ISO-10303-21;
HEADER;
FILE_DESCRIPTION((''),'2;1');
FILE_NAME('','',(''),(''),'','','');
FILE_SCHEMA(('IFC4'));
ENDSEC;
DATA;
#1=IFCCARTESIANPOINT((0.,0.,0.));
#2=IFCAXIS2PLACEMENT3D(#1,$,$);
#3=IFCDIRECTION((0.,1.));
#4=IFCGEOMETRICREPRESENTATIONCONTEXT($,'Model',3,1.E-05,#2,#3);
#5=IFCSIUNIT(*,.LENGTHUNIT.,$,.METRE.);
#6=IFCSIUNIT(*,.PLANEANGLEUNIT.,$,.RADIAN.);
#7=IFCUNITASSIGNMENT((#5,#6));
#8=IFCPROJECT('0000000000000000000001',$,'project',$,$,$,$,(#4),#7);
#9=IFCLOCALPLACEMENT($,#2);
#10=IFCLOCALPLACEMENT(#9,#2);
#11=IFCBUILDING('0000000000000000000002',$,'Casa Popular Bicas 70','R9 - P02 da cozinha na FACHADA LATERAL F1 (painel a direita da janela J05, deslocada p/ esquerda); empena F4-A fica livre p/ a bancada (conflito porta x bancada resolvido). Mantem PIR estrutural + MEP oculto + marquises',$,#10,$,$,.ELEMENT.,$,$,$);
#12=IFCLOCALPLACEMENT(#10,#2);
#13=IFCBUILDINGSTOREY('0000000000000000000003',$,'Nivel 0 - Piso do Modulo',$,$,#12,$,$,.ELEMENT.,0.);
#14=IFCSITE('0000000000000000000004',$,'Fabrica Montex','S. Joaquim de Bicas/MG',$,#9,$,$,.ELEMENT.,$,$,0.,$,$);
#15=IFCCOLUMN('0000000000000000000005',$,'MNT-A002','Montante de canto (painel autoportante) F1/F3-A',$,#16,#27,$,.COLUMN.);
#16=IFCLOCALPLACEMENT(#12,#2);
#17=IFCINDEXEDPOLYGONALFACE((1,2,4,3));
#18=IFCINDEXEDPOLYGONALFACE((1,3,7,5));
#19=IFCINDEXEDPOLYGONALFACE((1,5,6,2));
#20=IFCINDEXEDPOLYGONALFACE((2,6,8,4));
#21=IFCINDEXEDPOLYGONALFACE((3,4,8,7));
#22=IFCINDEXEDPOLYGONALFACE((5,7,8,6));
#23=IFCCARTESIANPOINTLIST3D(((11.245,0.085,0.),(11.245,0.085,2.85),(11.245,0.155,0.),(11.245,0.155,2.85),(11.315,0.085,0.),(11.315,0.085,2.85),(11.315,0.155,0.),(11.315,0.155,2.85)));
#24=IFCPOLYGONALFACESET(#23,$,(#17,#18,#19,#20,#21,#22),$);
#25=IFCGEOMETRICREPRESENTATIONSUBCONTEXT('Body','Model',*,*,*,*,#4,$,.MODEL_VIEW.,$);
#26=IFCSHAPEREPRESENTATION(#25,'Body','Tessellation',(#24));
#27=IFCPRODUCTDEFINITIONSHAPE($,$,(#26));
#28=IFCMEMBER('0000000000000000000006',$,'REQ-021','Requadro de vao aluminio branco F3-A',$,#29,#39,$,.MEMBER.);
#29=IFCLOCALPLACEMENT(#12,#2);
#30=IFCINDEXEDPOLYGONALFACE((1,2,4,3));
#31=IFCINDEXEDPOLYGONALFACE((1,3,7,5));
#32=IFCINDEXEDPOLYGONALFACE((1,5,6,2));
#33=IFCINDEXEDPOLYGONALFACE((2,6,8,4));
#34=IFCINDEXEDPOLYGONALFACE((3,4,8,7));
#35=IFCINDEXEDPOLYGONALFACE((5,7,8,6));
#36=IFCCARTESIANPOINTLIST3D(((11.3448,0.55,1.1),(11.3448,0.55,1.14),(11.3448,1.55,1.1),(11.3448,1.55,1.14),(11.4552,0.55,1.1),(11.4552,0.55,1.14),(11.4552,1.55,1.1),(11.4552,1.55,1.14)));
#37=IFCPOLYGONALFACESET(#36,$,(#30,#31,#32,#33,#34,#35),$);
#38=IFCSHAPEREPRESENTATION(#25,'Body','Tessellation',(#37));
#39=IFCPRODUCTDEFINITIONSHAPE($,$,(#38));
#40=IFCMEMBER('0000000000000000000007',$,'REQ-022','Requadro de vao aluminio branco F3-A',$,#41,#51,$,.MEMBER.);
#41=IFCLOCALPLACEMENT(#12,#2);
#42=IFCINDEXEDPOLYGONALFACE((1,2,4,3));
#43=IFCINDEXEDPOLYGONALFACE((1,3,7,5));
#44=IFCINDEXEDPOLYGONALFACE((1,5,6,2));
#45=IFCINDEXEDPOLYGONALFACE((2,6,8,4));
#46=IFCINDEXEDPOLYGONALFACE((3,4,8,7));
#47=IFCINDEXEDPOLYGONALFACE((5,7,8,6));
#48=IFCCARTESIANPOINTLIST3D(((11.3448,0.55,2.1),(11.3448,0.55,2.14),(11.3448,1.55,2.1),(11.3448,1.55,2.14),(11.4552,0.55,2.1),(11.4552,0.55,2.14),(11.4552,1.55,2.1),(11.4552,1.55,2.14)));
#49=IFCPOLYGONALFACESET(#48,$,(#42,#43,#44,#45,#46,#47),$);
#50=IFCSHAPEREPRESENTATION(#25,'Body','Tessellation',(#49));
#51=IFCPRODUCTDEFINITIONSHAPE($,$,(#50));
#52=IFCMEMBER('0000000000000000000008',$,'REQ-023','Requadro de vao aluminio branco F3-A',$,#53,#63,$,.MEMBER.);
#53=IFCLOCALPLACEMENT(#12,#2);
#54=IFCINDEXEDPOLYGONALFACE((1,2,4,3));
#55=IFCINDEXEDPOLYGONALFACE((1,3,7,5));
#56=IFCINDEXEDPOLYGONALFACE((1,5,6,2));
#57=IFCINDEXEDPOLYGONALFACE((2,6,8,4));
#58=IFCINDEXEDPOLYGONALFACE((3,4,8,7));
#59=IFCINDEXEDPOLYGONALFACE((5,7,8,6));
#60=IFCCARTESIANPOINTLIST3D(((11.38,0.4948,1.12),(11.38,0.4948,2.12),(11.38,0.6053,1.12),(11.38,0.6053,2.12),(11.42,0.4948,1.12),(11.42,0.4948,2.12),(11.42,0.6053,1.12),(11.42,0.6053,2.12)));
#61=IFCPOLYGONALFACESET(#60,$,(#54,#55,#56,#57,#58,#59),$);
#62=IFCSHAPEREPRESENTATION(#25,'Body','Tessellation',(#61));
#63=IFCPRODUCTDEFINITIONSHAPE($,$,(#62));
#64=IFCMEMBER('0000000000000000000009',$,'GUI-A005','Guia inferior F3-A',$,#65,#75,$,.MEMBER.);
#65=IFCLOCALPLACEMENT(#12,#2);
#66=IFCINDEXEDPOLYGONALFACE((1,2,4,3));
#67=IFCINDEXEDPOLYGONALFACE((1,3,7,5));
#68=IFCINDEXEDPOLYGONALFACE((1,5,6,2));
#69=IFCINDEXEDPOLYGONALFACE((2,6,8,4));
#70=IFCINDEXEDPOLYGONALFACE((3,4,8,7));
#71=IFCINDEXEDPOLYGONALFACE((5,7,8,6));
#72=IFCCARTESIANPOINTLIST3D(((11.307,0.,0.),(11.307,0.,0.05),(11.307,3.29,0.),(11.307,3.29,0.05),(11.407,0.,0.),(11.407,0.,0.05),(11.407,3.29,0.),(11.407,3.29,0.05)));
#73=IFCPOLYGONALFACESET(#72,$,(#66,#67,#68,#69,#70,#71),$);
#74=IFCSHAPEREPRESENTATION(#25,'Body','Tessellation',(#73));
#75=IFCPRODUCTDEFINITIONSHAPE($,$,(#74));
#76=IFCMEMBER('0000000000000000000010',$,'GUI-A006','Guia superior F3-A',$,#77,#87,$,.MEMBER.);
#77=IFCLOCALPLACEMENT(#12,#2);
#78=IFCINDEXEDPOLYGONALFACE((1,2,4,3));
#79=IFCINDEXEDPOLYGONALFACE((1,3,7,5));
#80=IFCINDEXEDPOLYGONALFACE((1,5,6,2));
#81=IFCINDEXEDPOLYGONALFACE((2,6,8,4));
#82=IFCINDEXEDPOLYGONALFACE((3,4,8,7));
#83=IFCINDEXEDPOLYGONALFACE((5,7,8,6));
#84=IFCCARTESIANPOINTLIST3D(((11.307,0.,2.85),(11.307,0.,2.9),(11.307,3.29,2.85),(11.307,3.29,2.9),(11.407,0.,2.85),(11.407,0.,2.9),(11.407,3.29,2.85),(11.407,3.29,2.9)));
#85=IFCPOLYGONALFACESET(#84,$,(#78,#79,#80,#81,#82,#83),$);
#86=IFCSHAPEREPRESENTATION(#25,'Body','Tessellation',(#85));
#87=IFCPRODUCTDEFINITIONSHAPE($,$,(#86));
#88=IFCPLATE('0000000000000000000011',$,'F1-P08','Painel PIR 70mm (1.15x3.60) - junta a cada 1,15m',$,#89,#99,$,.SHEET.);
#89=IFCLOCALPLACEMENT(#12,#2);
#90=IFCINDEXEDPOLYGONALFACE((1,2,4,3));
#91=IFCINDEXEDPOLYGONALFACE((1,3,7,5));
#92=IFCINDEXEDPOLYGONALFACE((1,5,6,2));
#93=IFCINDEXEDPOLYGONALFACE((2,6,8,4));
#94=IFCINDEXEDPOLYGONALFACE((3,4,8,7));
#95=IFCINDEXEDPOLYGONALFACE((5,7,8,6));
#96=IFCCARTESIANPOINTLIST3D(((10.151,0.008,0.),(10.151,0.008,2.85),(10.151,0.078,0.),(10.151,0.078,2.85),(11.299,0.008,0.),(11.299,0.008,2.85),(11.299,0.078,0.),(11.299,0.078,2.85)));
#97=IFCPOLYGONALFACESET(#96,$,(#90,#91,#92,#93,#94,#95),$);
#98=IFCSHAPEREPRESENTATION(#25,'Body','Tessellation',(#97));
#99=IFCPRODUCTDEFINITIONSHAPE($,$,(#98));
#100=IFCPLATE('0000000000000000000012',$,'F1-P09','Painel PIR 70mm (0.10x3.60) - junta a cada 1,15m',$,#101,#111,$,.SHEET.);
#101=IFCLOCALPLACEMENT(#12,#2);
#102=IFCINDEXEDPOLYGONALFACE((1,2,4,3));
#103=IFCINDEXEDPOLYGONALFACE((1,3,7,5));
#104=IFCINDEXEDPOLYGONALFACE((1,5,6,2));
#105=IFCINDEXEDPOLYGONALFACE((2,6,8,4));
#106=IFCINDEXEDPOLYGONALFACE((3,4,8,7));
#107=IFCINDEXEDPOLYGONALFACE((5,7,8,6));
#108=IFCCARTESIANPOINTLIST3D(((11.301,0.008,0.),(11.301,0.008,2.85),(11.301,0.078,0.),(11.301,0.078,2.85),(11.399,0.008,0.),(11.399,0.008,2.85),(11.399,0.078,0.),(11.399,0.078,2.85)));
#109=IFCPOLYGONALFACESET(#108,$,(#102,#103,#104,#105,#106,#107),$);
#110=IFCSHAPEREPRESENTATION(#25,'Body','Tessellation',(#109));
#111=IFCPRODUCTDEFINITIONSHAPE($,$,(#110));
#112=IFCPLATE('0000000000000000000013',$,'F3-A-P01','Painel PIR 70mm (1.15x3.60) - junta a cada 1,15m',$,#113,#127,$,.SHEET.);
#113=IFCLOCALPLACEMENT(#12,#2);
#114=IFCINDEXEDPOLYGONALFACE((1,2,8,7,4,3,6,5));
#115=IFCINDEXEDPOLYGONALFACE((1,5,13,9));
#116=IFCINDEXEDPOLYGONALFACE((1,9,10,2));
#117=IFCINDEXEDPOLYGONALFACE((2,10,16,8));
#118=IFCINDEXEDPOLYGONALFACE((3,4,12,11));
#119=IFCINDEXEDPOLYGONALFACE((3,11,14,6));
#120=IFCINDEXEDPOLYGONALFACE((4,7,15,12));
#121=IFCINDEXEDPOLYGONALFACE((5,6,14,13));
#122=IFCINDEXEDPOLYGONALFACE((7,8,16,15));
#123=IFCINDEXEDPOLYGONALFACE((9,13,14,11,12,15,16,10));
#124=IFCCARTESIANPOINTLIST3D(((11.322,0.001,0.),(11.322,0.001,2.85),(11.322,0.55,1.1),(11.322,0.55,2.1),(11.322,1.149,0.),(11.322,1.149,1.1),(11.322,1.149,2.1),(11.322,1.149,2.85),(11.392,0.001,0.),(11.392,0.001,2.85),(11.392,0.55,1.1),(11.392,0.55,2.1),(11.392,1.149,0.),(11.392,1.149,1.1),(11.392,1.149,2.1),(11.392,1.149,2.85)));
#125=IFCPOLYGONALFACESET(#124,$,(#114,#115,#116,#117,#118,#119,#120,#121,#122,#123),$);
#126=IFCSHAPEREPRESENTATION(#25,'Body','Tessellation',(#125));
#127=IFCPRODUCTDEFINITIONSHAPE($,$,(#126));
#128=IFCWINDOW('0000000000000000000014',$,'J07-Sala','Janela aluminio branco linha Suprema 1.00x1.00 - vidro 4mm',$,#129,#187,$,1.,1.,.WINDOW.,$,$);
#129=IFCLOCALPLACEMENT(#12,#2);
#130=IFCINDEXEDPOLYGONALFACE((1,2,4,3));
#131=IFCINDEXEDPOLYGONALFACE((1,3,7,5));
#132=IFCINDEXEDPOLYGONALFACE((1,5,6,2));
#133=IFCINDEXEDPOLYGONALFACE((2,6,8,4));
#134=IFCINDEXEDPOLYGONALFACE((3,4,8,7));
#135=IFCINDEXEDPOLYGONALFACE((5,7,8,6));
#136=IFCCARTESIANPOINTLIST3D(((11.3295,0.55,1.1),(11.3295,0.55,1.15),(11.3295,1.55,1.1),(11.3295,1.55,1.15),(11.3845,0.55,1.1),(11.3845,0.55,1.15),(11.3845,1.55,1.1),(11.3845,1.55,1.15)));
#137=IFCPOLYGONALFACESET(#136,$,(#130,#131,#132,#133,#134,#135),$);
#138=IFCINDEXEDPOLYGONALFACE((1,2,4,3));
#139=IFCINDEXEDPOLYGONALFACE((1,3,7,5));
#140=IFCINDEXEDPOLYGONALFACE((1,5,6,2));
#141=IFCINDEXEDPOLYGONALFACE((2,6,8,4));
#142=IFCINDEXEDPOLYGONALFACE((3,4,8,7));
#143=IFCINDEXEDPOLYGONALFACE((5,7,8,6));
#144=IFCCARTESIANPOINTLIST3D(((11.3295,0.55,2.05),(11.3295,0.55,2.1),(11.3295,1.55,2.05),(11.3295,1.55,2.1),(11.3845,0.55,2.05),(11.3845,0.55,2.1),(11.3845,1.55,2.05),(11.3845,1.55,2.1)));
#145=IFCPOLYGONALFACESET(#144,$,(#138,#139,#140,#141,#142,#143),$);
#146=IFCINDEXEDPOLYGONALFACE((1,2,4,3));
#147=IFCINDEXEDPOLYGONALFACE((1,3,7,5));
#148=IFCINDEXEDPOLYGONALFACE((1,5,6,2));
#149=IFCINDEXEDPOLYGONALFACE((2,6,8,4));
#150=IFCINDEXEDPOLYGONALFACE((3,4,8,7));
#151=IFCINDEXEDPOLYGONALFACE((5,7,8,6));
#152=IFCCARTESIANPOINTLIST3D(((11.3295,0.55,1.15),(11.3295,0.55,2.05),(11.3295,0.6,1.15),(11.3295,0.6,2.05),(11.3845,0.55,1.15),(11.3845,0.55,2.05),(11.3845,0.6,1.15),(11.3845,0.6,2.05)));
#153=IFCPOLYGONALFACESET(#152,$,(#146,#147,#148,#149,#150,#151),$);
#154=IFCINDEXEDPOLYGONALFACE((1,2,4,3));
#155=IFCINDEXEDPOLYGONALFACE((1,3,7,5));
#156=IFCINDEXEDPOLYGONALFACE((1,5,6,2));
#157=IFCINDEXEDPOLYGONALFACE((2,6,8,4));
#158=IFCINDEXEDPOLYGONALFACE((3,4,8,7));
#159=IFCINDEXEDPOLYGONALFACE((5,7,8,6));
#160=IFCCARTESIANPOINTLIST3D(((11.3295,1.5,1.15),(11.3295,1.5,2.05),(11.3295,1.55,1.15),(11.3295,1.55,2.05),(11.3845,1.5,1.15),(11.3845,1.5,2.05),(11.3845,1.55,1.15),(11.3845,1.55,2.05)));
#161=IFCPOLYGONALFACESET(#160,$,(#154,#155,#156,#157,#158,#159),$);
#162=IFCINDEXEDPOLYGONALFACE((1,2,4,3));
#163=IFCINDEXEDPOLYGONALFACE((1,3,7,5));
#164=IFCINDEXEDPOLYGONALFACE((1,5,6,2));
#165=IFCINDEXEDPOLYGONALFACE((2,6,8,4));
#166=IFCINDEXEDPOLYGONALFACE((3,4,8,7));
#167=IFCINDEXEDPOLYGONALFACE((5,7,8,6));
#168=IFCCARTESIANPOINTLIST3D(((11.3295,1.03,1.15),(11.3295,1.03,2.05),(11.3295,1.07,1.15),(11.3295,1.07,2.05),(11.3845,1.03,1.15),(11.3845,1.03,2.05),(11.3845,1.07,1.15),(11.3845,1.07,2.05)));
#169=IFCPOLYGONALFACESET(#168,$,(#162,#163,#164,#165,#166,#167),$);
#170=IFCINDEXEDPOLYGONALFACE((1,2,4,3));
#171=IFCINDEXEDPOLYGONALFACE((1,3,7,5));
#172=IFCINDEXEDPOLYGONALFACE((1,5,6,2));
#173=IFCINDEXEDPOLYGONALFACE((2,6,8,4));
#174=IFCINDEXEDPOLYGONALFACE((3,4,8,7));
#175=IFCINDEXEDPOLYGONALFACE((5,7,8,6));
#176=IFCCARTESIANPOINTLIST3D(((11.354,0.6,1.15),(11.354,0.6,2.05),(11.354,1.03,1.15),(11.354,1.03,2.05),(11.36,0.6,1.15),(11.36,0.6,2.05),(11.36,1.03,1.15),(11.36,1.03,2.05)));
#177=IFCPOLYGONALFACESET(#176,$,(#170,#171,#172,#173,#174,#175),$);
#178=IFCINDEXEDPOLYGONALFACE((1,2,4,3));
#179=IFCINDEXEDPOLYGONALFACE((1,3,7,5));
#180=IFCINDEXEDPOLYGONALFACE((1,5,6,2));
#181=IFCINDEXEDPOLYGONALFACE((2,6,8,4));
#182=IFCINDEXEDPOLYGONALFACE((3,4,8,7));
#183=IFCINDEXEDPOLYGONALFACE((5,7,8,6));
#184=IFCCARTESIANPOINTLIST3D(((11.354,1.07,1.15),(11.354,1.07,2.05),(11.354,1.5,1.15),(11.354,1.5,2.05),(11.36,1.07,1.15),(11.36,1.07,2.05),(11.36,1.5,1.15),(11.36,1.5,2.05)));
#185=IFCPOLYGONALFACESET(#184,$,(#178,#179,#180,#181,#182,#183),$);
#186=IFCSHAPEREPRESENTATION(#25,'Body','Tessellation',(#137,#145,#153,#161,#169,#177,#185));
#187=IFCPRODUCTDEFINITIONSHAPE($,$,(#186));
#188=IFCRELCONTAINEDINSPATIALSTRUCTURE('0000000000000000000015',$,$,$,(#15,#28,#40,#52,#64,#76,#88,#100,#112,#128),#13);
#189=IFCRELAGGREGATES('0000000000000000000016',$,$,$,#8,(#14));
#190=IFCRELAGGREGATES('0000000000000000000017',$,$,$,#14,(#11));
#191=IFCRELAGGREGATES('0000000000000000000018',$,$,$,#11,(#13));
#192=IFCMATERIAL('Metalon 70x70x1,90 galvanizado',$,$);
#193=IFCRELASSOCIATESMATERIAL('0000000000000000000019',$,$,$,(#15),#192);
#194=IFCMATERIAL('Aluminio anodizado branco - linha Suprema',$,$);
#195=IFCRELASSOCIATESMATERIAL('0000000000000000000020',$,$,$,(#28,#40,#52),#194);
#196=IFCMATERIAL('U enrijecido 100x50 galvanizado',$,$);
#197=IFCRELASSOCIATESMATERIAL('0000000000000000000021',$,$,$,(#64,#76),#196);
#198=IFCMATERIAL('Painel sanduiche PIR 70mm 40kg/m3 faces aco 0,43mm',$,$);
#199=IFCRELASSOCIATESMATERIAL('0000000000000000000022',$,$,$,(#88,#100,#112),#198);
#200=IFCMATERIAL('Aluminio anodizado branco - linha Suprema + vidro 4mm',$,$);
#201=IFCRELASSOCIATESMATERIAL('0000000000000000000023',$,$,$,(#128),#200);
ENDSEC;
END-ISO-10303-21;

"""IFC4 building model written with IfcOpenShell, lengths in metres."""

from ifc_helpers import new_model, si_unit, direction, frame, frame_2d, origin, origin_2d, place, context, subcontext, project, spatial, rectangle, extrude, material, element, fill, save


model = new_model("IFC4")

# Units and contexts
model_context = context("Model", 3, precision=1e-05, world=origin(), true_north=direction((0.0, 1.0)))
body_context = subcontext(model_context, "Body", "Model", "MODEL_VIEW")
ifc_project = project(units=[si_unit("LENGTHUNIT", "METRE"), si_unit("PLANEANGLEUNIT", "RADIAN")], contexts=[model_context])

# Site, building, storey
site_placement = place(None, origin())
site = spatial("IfcSite", under=ifc_project, at=site_placement, Name="Fabrica Montex", Description="S. Joaquim de Bicas/MG", CompositionType="ELEMENT", RefElevation=0.0)
building_placement = place(site_placement, origin())
building = spatial("IfcBuilding", under=site, at=building_placement, Name="Casa Popular Bicas 70", Description="R9 - P02 da cozinha na FACHADA LATERAL F1 (painel a direita da janela J05, deslocada p/ esquerda); empena F4-A fica livre p/ a bancada (conflito porta x bancada resolvido). Mantem PIR estrutural + MEP oculto + marquises", CompositionType="ELEMENT")
storey_placement = place(building_placement, origin())
storey = spatial("IfcBuildingStorey", under=building, at=storey_placement, Name="Nivel 0 - Piso do Modulo", CompositionType="ELEMENT", Elevation=0.0)

# Column
ifc_material_1 = material(Name="Metalon 70x70x1,90 galvanizado")
column_placement = place(storey_placement, frame((11.28, 0.12, 0.0)))
element("IfcColumn", 1, at=column_placement, inside=storey, material=ifc_material_1, Name="MNT-A002", Description="Montante de canto (painel autoportante) F1/F3-A", PredefinedType="COLUMN", context=body_context, shape_type="SweptSolid", body=[
    extrude(rectangle(XDim=0.07, YDim=0.07, at=origin_2d()), origin(), (0.0, 0.0, 1.0), 2.85),
])

# Members
ifc_material_2 = material(Name="Aluminio anodizado branco - linha Suprema")
for number, where, z_axis, x_axis, name in (
    (2, (11.4, 0.55, 1.12), (0.0, 1.0, 0.0), (0.0, 0.0, 1.0), "REQ-021"),
    (3, (11.4, 0.55, 2.12), (0.0, 1.0, 0.0), (0.0, 0.0, 1.0), "REQ-022"),
    (4, (11.4, 0.55, 1.12), (0.0, 0.0, 1.0), (1.0, 0.0, 0.0), "REQ-023"),
):
    element("IfcMember", number, at=place(storey_placement, frame(where, z_axis=z_axis, x_axis=x_axis)), inside=storey, material=ifc_material_2, Name=name, Description="Requadro de vao aluminio branco F3-A", PredefinedType="MEMBER", context=body_context, shape_type="SweptSolid", body=[
        extrude(rectangle(XDim=0.04, YDim=0.1105, at=origin_2d()), origin(), (0.0, 0.0, 1.0), 1.0),
    ])
ifc_material_3 = material(Name="U enrijecido 100x50 galvanizado")
for number, where, z_axis, x_axis, name, description in (
    (5, (11.357, 0.0, 0.025), (0.0, 1.0, 0.0), (0.0, 0.0, 1.0), "GUI-A005", "Guia inferior F3-A"),
    (6, (11.357, 0.0, 2.875), (0.0, 1.0, 0.0), (0.0, 0.0, 1.0), "GUI-A006", "Guia superior F3-A"),
):
    element("IfcMember", number, at=place(storey_placement, frame(where, z_axis=z_axis, x_axis=x_axis)), inside=storey, material=ifc_material_3, Name=name, Description=description, PredefinedType="MEMBER", context=body_context, shape_type="SweptSolid", body=[
        extrude(rectangle(XDim=0.05, YDim=0.1, at=origin_2d()), origin(), (0.0, 0.0, 1.0), 3.29),
    ])

# Plates
ifc_material_4 = material(Name="Painel sanduiche PIR 70mm 40kg/m3 faces aco 0,43mm")
plate_1_placement = place(storey_placement, frame((10.151, 0.043, 0.0), x_axis=(1.0, 0.0, 0.0)))
element("IfcPlate", 7, at=plate_1_placement, inside=storey, material=ifc_material_4, Name="F1-P08", Description="Painel PIR 70mm (1.15x3.60) - junta a cada 1,15m", PredefinedType="SHEET", context=body_context, shape_type="SweptSolid", body=[
    extrude(rectangle(XDim=1.148, YDim=0.07, at=frame_2d((0.574, 0.0))), origin(), (0.0, 0.0, 1.0), 2.85),
])
plate_2_placement = place(storey_placement, frame((11.301, 0.043, 0.0), x_axis=(1.0, 0.0, 0.0)))
element("IfcPlate", 8, at=plate_2_placement, inside=storey, material=ifc_material_4, Name="F1-P09", Description="Painel PIR 70mm (0.10x3.60) - junta a cada 1,15m", PredefinedType="SHEET", context=body_context, shape_type="SweptSolid", body=[
    extrude(rectangle(XDim=0.098, YDim=0.07, at=frame_2d((0.049, 0.0))), origin(), (0.0, 0.0, 1.0), 2.85),
])

# Plate, opening, window
plate_3_placement = place(storey_placement, frame((11.357, 0.001, 0.0), x_axis=(0.0, 1.0, 0.0)))
plate_3 = element("IfcPlate", 9, at=plate_3_placement, inside=storey, material=ifc_material_4, Name="F3-A-P01", Description="Painel PIR 70mm (1.15x3.60) - junta a cada 1,15m", PredefinedType="SHEET", context=body_context, shape_type="SweptSolid", body=[
    extrude(rectangle(XDim=1.148, YDim=0.07, at=frame_2d((0.574, 0.0))), origin(), (0.0, 0.0, 1.0), 2.85),
])
opening_1_placement = place(storey_placement, frame((11.357, 0.85, 1.1)))
opening_1 = element("IfcOpeningElement", 10, at=opening_1_placement, cuts=plate_3, PredefinedType="OPENING", context=body_context, shape_type="SweptSolid", body=[
    extrude(rectangle(XDim=0.1, YDim=0.6, at=origin_2d()), origin(), (0.0, 0.0, 1.0), 1.0),
])
ifc_material_5 = material(Name="Aluminio anodizado branco - linha Suprema + vidro 4mm")
window_placement = place(storey_placement, frame((11.357, 0.55, 1.1), x_axis=(0.0, 1.0, 0.0)))
window = element("IfcWindow", 11, at=window_placement, inside=storey, material=ifc_material_5, Name="J07-Sala", Description="Janela aluminio branco linha Suprema 1.00x1.00 - vidro 4mm", OverallHeight=1.0, OverallWidth=1.0, PredefinedType="WINDOW", context=body_context, shape_type="SweptSolid", body=[
    extrude(rectangle(XDim=1.0, YDim=0.055, at=frame_2d((0.5, 0.0))), origin(), (0.0, 0.0, 1.0), 0.05),
    extrude(rectangle(XDim=1.0, YDim=0.055, at=frame_2d((0.5, 0.0))), frame((0.0, 0.0, 0.95)), (0.0, 0.0, 1.0), 0.05),
    extrude(rectangle(XDim=0.05, YDim=0.055, at=frame_2d((0.025, 0.0))), frame((0.0, 0.0, 0.05)), (0.0, 0.0, 1.0), 0.9),
    extrude(rectangle(XDim=0.05, YDim=0.055, at=frame_2d((0.975, 0.0))), frame((0.0, 0.0, 0.05)), (0.0, 0.0, 1.0), 0.9),
    extrude(rectangle(XDim=0.04, YDim=0.055, at=frame_2d((0.5, 0.0))), frame((0.0, 0.0, 0.05)), (0.0, 0.0, 1.0), 0.9),
    extrude(rectangle(XDim=0.43, YDim=0.006, at=frame_2d((0.265, 0.0))), frame((0.0, 0.0, 0.05)), (0.0, 0.0, 1.0), 0.9),
    extrude(rectangle(XDim=0.43, YDim=0.006, at=frame_2d((0.735, 0.0))), frame((0.0, 0.0, 0.05)), (0.0, 0.0, 1.0), 0.9),
])
fill(opening_1, window)

save(model, "model.ifc")
